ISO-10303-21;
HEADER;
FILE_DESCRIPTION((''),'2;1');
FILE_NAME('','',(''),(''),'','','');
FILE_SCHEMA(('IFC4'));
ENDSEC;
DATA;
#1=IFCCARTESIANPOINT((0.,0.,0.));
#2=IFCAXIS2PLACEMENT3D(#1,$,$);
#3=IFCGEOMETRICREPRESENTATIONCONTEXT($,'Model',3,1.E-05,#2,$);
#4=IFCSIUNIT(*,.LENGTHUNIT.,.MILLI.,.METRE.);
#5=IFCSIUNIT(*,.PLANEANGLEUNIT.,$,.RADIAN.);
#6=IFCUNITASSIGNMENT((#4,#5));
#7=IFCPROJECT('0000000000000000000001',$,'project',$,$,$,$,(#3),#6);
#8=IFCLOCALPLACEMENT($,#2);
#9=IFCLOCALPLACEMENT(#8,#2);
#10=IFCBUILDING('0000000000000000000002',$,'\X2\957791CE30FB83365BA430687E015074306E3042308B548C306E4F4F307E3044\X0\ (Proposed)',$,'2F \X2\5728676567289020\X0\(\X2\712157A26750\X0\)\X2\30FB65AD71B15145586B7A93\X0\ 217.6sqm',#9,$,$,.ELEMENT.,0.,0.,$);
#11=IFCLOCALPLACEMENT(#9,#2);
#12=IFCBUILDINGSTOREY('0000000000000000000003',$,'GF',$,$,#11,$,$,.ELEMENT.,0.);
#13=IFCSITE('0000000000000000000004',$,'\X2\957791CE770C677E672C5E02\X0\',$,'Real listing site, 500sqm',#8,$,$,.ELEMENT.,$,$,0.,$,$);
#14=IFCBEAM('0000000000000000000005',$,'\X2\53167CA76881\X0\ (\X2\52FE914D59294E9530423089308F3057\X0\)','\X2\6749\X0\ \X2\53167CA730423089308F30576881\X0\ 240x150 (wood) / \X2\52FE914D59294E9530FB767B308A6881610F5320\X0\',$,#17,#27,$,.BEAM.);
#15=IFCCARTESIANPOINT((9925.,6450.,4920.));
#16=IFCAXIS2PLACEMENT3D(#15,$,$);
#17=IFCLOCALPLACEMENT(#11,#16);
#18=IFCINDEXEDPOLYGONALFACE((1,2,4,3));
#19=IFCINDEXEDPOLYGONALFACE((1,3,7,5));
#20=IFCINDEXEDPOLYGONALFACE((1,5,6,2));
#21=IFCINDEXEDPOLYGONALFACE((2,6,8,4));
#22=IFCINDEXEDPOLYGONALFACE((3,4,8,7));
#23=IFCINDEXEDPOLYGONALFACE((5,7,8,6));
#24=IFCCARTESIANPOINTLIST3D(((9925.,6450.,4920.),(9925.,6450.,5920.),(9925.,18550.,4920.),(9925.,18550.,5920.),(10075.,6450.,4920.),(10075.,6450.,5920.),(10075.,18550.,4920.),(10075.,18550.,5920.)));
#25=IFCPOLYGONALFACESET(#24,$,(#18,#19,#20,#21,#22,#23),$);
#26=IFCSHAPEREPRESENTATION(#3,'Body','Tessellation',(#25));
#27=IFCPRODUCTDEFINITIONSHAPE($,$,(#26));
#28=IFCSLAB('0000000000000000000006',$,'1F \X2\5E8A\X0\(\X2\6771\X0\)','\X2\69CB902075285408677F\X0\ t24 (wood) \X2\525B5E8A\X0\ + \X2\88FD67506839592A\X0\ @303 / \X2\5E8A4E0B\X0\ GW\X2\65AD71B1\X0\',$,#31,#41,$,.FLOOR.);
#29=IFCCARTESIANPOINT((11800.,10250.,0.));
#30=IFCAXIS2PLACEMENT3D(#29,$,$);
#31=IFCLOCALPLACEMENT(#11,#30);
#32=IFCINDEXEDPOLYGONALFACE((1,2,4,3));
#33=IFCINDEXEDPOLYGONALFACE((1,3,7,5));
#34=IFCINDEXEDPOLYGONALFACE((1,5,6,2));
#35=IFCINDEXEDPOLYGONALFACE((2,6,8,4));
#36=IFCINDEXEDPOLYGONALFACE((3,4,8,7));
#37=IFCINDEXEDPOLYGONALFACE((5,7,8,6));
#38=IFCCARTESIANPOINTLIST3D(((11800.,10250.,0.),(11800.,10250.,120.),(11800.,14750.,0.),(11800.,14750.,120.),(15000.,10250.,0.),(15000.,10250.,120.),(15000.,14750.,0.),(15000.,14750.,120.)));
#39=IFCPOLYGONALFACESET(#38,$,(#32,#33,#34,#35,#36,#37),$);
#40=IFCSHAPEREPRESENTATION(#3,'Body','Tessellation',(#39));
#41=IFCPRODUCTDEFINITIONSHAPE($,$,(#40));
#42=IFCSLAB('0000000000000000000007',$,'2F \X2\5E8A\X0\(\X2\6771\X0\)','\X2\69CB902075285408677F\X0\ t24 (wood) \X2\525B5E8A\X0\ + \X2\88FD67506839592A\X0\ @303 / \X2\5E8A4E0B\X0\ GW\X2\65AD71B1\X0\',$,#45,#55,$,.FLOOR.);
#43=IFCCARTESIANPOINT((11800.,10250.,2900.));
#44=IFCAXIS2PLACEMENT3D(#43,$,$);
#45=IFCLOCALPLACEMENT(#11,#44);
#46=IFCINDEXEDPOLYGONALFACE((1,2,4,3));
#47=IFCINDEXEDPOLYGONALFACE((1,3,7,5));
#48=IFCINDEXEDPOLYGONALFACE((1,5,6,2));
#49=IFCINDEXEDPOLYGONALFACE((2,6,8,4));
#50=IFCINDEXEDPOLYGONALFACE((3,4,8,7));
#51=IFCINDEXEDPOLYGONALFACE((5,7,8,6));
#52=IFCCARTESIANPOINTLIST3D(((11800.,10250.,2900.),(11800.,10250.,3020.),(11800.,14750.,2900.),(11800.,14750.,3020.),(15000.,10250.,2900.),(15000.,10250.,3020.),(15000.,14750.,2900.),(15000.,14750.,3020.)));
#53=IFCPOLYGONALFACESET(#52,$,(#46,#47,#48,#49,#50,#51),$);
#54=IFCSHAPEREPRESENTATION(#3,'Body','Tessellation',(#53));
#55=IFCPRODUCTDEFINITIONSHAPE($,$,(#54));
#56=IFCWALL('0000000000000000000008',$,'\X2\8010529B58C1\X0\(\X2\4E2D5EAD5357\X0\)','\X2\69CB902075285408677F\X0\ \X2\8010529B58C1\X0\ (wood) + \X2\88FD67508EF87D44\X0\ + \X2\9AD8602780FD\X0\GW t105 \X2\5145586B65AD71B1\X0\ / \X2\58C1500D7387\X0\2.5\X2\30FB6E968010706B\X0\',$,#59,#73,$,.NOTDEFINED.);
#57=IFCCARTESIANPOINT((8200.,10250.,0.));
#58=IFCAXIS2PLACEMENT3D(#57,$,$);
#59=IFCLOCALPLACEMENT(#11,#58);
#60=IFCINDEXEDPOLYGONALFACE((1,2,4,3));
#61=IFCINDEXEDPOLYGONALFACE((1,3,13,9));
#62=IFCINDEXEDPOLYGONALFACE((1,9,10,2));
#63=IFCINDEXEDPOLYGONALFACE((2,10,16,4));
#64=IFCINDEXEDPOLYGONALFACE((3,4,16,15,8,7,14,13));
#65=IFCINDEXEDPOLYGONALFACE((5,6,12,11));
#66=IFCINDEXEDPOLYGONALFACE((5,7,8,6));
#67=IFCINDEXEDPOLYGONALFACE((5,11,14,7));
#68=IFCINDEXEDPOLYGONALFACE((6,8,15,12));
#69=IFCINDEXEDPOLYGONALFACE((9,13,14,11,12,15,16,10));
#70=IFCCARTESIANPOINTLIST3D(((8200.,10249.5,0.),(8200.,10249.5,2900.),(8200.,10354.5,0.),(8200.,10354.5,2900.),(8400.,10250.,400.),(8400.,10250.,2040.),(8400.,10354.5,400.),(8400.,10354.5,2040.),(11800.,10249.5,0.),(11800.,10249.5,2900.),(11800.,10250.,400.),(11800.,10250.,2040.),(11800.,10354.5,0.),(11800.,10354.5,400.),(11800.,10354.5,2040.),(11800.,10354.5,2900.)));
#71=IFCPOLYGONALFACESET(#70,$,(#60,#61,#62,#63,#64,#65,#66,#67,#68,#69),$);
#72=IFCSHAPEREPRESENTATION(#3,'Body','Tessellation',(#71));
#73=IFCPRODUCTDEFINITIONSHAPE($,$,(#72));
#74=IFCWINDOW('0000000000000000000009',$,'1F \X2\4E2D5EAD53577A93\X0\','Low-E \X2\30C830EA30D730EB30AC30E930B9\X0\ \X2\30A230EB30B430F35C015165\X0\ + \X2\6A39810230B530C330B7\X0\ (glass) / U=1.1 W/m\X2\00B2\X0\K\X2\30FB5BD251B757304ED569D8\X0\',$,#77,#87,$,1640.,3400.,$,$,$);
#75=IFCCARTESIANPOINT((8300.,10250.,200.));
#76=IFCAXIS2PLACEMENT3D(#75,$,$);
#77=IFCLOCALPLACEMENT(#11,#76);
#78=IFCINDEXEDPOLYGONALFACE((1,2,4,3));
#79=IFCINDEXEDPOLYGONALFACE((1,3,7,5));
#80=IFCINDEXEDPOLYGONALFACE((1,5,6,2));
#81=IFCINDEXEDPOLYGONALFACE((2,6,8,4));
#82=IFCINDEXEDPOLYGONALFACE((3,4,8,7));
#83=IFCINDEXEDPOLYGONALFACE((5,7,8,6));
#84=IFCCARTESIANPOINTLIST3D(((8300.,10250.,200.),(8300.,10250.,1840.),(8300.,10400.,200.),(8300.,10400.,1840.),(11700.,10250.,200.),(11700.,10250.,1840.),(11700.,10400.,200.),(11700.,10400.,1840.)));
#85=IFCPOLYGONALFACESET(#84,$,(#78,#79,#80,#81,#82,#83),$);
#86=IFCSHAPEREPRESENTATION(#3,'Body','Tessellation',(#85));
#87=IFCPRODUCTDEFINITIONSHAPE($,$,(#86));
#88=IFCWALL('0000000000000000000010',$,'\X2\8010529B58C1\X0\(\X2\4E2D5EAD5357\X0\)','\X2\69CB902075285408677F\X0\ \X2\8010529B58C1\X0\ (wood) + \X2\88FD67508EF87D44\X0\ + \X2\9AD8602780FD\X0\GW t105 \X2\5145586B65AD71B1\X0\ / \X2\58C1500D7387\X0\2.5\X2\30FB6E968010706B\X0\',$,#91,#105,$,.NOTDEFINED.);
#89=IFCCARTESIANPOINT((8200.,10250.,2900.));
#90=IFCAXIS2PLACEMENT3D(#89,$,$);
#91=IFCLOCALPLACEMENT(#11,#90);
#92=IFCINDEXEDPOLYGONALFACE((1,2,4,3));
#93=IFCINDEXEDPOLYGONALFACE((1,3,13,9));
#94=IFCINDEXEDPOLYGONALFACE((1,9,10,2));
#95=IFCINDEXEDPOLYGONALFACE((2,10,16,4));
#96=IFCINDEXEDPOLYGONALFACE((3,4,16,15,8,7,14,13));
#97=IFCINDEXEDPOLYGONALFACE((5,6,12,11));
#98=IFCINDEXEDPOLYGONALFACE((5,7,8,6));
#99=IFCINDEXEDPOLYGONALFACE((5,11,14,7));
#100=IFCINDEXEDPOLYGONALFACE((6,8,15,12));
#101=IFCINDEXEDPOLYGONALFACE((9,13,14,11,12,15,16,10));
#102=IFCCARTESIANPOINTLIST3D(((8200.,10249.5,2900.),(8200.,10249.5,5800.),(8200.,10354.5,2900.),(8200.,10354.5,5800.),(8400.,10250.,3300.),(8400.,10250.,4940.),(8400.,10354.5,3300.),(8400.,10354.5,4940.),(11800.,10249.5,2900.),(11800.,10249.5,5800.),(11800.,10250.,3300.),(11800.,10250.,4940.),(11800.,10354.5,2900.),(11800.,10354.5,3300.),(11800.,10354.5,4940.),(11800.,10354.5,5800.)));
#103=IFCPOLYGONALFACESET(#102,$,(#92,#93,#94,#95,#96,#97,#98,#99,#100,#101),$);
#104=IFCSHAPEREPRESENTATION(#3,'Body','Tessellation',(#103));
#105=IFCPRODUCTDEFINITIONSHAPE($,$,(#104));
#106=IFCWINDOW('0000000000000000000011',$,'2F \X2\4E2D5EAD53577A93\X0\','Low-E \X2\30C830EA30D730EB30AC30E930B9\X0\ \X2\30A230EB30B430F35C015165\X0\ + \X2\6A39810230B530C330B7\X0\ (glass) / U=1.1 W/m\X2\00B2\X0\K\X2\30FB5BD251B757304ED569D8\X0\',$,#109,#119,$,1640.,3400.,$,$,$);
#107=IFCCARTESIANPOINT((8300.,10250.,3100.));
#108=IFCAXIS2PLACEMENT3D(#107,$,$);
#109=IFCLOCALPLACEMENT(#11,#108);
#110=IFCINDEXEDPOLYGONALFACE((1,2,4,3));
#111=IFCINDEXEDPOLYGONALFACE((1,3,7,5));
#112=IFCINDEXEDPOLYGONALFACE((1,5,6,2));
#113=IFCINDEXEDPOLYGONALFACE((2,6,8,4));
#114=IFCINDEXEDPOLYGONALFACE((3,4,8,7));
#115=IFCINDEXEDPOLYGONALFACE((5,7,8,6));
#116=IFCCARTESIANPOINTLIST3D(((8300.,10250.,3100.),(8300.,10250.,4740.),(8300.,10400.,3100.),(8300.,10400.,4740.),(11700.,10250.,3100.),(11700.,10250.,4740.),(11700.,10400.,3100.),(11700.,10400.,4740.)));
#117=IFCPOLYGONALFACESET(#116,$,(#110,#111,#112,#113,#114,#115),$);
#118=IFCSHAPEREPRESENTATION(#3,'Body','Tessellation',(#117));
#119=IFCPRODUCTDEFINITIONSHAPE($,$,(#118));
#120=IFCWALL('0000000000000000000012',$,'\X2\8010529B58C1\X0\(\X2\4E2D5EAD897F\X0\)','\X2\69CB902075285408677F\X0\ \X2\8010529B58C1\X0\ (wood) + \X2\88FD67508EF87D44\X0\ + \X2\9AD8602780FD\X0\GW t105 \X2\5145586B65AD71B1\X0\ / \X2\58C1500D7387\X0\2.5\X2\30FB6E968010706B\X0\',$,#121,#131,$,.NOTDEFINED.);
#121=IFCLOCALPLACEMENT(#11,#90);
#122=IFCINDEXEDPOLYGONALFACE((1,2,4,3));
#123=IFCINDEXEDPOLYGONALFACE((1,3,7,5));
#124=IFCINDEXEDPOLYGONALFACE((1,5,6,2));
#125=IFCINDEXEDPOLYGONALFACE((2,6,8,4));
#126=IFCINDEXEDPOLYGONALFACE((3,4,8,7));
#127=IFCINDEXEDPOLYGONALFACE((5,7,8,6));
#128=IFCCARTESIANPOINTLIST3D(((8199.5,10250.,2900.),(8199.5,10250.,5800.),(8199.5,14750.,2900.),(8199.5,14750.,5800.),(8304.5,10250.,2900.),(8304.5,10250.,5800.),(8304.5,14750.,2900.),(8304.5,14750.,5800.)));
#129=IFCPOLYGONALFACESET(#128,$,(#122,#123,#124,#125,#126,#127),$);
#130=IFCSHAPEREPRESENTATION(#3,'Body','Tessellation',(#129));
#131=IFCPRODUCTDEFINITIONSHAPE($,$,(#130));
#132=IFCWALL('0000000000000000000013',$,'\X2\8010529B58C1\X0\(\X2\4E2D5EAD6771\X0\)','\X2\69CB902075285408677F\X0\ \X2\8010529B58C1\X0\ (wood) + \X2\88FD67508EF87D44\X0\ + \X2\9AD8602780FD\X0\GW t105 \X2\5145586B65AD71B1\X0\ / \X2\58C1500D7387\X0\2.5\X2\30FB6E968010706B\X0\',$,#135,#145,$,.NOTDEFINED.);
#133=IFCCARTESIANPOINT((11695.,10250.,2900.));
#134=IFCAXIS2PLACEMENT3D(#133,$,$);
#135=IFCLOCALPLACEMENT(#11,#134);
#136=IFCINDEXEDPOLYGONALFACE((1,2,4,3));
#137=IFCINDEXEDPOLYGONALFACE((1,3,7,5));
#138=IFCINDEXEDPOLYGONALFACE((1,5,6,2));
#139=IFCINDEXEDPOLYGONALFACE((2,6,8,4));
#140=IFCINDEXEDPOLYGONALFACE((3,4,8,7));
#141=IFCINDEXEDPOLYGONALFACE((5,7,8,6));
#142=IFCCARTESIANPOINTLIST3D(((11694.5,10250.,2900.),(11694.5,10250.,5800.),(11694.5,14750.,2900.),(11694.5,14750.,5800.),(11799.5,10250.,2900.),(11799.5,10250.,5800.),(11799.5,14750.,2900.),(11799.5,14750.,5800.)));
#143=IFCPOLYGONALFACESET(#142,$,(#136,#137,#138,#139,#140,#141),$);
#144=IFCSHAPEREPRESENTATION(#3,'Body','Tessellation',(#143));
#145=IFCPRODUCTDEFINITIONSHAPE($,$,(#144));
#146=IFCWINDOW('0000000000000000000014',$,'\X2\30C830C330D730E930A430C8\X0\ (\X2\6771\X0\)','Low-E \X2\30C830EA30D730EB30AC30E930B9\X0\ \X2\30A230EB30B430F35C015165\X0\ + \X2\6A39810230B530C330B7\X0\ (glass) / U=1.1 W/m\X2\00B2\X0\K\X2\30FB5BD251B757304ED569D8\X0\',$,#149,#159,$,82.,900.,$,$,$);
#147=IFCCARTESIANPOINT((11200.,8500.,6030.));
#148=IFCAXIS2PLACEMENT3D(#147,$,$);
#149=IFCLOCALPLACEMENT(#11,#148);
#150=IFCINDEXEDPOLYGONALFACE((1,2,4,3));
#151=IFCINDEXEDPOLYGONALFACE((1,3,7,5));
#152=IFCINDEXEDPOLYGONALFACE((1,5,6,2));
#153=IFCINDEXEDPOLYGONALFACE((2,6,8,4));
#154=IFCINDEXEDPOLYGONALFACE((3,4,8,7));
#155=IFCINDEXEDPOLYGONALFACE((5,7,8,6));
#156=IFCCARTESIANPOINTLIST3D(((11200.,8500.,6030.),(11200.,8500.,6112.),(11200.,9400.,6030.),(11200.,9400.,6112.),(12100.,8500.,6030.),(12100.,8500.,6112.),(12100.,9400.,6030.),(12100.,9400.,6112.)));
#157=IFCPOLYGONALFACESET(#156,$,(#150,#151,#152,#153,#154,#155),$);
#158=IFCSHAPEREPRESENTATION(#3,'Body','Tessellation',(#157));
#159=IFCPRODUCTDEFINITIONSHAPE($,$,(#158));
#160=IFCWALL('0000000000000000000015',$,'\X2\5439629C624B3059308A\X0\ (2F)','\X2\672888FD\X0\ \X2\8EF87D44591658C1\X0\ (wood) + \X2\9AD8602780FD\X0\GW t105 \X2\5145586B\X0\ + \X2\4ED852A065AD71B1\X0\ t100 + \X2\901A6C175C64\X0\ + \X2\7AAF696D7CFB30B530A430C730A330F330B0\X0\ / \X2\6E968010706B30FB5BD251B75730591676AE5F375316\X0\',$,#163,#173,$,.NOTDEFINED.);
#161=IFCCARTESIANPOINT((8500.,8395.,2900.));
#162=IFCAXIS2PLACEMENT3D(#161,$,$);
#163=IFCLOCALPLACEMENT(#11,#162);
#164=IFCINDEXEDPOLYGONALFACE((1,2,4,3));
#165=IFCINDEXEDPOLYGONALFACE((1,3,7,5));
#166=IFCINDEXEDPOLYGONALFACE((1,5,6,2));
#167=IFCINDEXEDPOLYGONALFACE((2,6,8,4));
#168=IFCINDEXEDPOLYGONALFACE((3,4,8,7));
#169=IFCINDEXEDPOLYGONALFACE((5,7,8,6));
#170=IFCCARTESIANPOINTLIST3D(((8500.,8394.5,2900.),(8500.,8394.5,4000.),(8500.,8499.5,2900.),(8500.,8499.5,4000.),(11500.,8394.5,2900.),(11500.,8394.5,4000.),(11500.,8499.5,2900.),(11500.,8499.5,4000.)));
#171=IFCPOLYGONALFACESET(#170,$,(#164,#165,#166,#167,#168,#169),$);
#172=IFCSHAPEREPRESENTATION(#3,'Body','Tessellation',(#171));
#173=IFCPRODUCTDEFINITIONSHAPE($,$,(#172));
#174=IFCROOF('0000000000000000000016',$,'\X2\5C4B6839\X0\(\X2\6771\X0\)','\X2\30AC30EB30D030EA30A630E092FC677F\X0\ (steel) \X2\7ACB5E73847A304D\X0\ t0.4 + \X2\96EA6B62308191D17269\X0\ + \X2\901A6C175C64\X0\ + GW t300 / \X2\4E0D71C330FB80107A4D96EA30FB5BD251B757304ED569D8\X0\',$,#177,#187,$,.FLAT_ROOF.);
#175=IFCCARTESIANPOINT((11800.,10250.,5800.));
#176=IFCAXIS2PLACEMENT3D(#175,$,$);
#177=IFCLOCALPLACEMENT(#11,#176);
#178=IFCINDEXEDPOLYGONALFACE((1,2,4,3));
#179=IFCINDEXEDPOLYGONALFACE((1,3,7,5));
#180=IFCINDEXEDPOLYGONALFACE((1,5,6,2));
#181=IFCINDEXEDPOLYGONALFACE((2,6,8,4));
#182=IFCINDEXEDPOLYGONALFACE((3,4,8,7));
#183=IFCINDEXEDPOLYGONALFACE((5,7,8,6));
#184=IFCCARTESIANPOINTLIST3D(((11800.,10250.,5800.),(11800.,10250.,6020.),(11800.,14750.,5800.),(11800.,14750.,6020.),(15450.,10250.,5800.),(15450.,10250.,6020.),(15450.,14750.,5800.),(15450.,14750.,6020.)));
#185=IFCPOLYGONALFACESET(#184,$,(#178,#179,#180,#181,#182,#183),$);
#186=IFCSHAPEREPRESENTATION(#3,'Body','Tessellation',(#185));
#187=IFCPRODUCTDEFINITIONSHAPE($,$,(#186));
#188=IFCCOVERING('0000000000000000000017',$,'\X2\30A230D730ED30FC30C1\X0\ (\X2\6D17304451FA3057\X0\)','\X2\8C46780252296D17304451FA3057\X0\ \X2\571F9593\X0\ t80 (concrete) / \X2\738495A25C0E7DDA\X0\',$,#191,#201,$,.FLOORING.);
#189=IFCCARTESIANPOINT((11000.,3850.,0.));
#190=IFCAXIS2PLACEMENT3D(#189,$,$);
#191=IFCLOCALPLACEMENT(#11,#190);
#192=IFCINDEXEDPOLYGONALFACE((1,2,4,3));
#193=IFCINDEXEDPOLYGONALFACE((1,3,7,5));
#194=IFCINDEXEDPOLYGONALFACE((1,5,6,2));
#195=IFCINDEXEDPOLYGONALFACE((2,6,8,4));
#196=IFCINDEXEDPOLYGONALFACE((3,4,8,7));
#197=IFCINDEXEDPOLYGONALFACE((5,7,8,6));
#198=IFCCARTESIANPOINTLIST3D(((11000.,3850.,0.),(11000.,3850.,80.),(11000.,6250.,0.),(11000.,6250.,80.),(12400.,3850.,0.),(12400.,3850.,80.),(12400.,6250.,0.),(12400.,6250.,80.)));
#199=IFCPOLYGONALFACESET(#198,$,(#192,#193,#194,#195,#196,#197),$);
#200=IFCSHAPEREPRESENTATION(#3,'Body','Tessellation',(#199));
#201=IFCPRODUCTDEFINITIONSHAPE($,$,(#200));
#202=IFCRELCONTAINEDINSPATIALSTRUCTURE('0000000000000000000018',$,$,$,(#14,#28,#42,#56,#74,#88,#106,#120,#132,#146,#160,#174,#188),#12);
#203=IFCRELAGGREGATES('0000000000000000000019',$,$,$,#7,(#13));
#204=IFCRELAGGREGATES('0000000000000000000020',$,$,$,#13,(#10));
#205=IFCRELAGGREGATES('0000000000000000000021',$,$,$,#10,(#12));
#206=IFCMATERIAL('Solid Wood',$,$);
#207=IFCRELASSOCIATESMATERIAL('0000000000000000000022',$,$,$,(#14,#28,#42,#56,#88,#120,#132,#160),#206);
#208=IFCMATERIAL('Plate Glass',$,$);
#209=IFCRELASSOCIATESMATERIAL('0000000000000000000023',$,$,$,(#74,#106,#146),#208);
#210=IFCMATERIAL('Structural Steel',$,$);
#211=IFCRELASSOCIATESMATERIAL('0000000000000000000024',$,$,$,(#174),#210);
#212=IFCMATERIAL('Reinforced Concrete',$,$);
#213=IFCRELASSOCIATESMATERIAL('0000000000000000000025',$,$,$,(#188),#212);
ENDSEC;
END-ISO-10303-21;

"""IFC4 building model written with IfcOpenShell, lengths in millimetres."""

from ifc_helpers import new_model, si_unit, frame, frame_2d, origin, place, context, project, spatial, rectangle, extrude, material, element, fill, save


model = new_model("IFC4")

# Units and contexts
model_context = context("Model", 3, precision=1e-05, world=origin())
ifc_project = project(units=[si_unit("LENGTHUNIT", "METRE", prefix="MILLI"), si_unit("PLANEANGLEUNIT", "RADIAN")], contexts=[model_context])

# Site, building, storey
site_placement = place(None, origin())
site = spatial("IfcSite", under=ifc_project, at=site_placement, Name="長野県松本市", ObjectType="Real listing site, 500sqm", CompositionType="ELEMENT", RefElevation=0.0)
building_placement = place(site_placement, origin())
building = spatial("IfcBuilding", under=site, at=building_placement, Name="長野・茶室と縁側のある和の住まい (Proposed)", ObjectType="2F 在来木造(無垢材)・断熱充填窓 217.6sqm", CompositionType="ELEMENT", ElevationOfRefHeight=0.0, ElevationOfTerrain=0.0)
storey_placement = place(building_placement, origin())
storey = spatial("IfcBuildingStorey", under=building, at=storey_placement, Name="GF", CompositionType="ELEMENT", Elevation=0.0)

# Shared definitions
ifc_material_1 = material(Name="Solid Wood")

# Beam
beam_placement = place(storey_placement, frame((9925.0, 6450.0, 4920.0)))
element("IfcBeam", 1, at=beam_placement, inside=storey, material=ifc_material_1, Name="化粧梁 (勾配天井あらわし)", Description="杉 化粧あらわし梁 240x150 (wood) / 勾配天井・登り梁意匠", PredefinedType="BEAM", context=model_context, shape_type="SweptSolid", body=[
    extrude(rectangle(XDim=150.0, YDim=12100.0, at=frame_2d((75.0, 6050.0))), frame((9925.0, 6450.0, 4920.0)), (0.0, 0.0, 1.0), 1000.0),
])

# Slabs
slab_1_placement = place(storey_placement, frame((11800.0, 10250.0, 0.0)))
element("IfcSlab", 2, at=slab_1_placement, inside=storey, material=ifc_material_1, Name="1F 床(東)", Description="構造用合板 t24 (wood) 剛床 + 製材根太 @303 / 床下 GW断熱", PredefinedType="FLOOR", context=model_context, shape_type="SweptSolid", body=[
    extrude(rectangle(XDim=3200.0, YDim=4500.0, at=frame_2d((1600.0, 2250.0))), frame((11800.0, 10250.0, 0.0)), (0.0, 0.0, 1.0), 120.0),
])
slab_2_placement = place(storey_placement, frame((11800.0, 10250.0, 2900.0)))
element("IfcSlab", 3, at=slab_2_placement, inside=storey, material=ifc_material_1, Name="2F 床(東)", Description="構造用合板 t24 (wood) 剛床 + 製材根太 @303 / 床下 GW断熱", PredefinedType="FLOOR", context=model_context, shape_type="SweptSolid", body=[
    extrude(rectangle(XDim=3200.0, YDim=4500.0, at=frame_2d((1600.0, 2250.0))), frame((11800.0, 10250.0, 2900.0)), (0.0, 0.0, 1.0), 120.0),
])

# Wall, opening, window
wall_1_placement = place(storey_placement, frame((8200.0, 10250.0, 0.0)))
wall_1 = element("IfcWall", 4, at=wall_1_placement, inside=storey, material=ifc_material_1, Name="耐力壁(中庭南)", Description="構造用合板 耐力壁 (wood) + 製材軸組 + 高性能GW t105 充填断熱 / 壁倍率2.5・準耐火", PredefinedType="NOTDEFINED", context=model_context, shape_type="SweptSolid", body=[
    extrude(rectangle(XDim=3600.0, YDim=105.0, at=frame_2d((1800.0, 52.0))), frame((8200.0, 10250.0, 0.0)), (0.0, 0.0, 1.0), 2900.0),
])
opening_1_placement = place(storey_placement, frame((8300.0, 10250.0, 200.0)))
opening_1 = element("IfcOpeningElement", 5, at=opening_1_placement, cuts=wall_1, PredefinedType="NOTDEFINED", context=model_context, shape_type="SweptSolid", body=[
    extrude(rectangle(XDim=3400.0, YDim=150.0, at=frame_2d((1700.0, 75.0))), frame((8300.0, 10250.0, 200.0)), (0.0, 0.0, 1.0), 1640.0),
])
ifc_material_2 = material(Name="Plate Glass")
window_1_placement = place(storey_placement, frame((8300.0, 10250.0, 200.0)))
window_1 = element("IfcWindow", 6, at=window_1_placement, inside=storey, material=ifc_material_2, Name="1F 中庭南窓", Description="Low-E トリプルガラス アルゴン封入 + 樹脂サッシ (glass) / U=1.1 W/m²K・寒冷地仕様", OverallHeight=1640.0, OverallWidth=3400.0, context=model_context, shape_type="SweptSolid", body=[
    extrude(rectangle(XDim=3400.0, YDim=150.0, at=frame_2d((1700.0, 75.0))), frame((8300.0, 10250.0, 200.0)), (0.0, 0.0, 1.0), 1640.0),
])
fill(opening_1, window_1)

# Wall, opening, window
wall_2_placement = place(storey_placement, frame((8200.0, 10250.0, 2900.0)))
wall_2 = element("IfcWall", 7, at=wall_2_placement, inside=storey, material=ifc_material_1, Name="耐力壁(中庭南)", Description="構造用合板 耐力壁 (wood) + 製材軸組 + 高性能GW t105 充填断熱 / 壁倍率2.5・準耐火", PredefinedType="NOTDEFINED", context=model_context, shape_type="SweptSolid", body=[
    extrude(rectangle(XDim=3600.0, YDim=105.0, at=frame_2d((1800.0, 52.0))), frame((8200.0, 10250.0, 2900.0)), (0.0, 0.0, 1.0), 2900.0),
])
opening_2_placement = place(storey_placement, frame((8300.0, 10250.0, 3100.0)))
opening_2 = element("IfcOpeningElement", 8, at=opening_2_placement, cuts=wall_2, PredefinedType="NOTDEFINED", context=model_context, shape_type="SweptSolid", body=[
    extrude(rectangle(XDim=3400.0, YDim=150.0, at=frame_2d((1700.0, 75.0))), frame((8300.0, 10250.0, 3100.0)), (0.0, 0.0, 1.0), 1640.0),
])
window_2_placement = place(storey_placement, frame((8300.0, 10250.0, 3100.0)))
window_2 = element("IfcWindow", 9, at=window_2_placement, inside=storey, material=ifc_material_2, Name="2F 中庭南窓", Description="Low-E トリプルガラス アルゴン封入 + 樹脂サッシ (glass) / U=1.1 W/m²K・寒冷地仕様", OverallHeight=1640.0, OverallWidth=3400.0, context=model_context, shape_type="SweptSolid", body=[
    extrude(rectangle(XDim=3400.0, YDim=150.0, at=frame_2d((1700.0, 75.0))), frame((8300.0, 10250.0, 3100.0)), (0.0, 0.0, 1.0), 1640.0),
])
fill(opening_2, window_2)

# Walls
wall_3_placement = place(storey_placement, frame((8200.0, 10250.0, 2900.0)))
element("IfcWall", 10, at=wall_3_placement, inside=storey, material=ifc_material_1, Name="耐力壁(中庭西)", Description="構造用合板 耐力壁 (wood) + 製材軸組 + 高性能GW t105 充填断熱 / 壁倍率2.5・準耐火", PredefinedType="NOTDEFINED", context=model_context, shape_type="SweptSolid", body=[
    extrude(rectangle(XDim=105.0, YDim=4500.0, at=frame_2d((52.0, 2250.0))), frame((8200.0, 10250.0, 2900.0)), (0.0, 0.0, 1.0), 2900.0),
])
wall_4_placement = place(storey_placement, frame((11695.0, 10250.0, 2900.0)))
element("IfcWall", 11, at=wall_4_placement, inside=storey, material=ifc_material_1, Name="耐力壁(中庭東)", Description="構造用合板 耐力壁 (wood) + 製材軸組 + 高性能GW t105 充填断熱 / 壁倍率2.5・準耐火", PredefinedType="NOTDEFINED", context=model_context, shape_type="SweptSolid", body=[
    extrude(rectangle(XDim=105.0, YDim=4500.0, at=frame_2d((52.0, 2250.0))), frame((11695.0, 10250.0, 2900.0)), (0.0, 0.0, 1.0), 2900.0),
])

# Window
window_3_placement = place(storey_placement, frame((11200.0, 8500.0, 6030.0)))
element("IfcWindow", 12, at=window_3_placement, inside=storey, material=ifc_material_2, Name="トップライト (東)", Description="Low-E トリプルガラス アルゴン封入 + 樹脂サッシ (glass) / U=1.1 W/m²K・寒冷地仕様", OverallHeight=82.0, OverallWidth=900.0, context=model_context, shape_type="SweptSolid", body=[
    extrude(rectangle(XDim=900.0, YDim=900.0, at=frame_2d((450.0, 450.0))), frame((11200.0, 8500.0, 6030.0)), (0.0, 0.0, 1.0), 82.0),
])

# Wall
wall_5_placement = place(storey_placement, frame((8500.0, 8395.0, 2900.0)))
element("IfcWall", 13, at=wall_5_placement, inside=storey, material=ifc_material_1, Name="吹抜手すり (2F)", Description="木製 軸組外壁 (wood) + 高性能GW t105 充填 + 付加断熱 t100 + 通気層 + 窯業系サイディング / 準耐火・寒冷地外皮強化", PredefinedType="NOTDEFINED", context=model_context, shape_type="SweptSolid", body=[
    extrude(rectangle(XDim=3000.0, YDim=105.0, at=frame_2d((1500.0, 52.0))), frame((8500.0, 8395.0, 2900.0)), (0.0, 0.0, 1.0), 1100.0),
])

# Roof
ifc_material_3 = material(Name="Structural Steel")
for number, where, name in (
    (14, (11800.0, 10250.0, 5800.0), "屋根(東)"),
):
    element("IfcRoof", number, at=place(storey_placement, frame(where)), inside=storey, material=ifc_material_3, Name=name, Description="ガルバリウム鋼板 (steel) 立平葺き t0.4 + 雪止め金物 + 通気層 + GW t300 / 不燃・耐積雪・寒冷地仕様", PredefinedType="FLAT_ROOF", context=model_context, shape_type="SweptSolid", body=[
        extrude(rectangle(XDim=3650.0, YDim=4500.0, at=frame_2d((1825.0, 2250.0))), frame((11800.0, 10250.0, 5800.0)), (0.0, 0.0, 1.0), 220.0),
    ])

# Covering
ifc_material_4 = material(Name="Reinforced Concrete")
covering_placement = place(storey_placement, frame((11000.0, 3850.0, 0.0)))
element("IfcCovering", 15, at=covering_placement, inside=storey, material=ifc_material_4, Name="アプローチ (洗い出し)", Description="豆砂利洗い出し 土間 t80 (concrete) / 玄関導線", PredefinedType="FLOORING", context=model_context, shape_type="SweptSolid", body=[
    extrude(rectangle(XDim=1400.0, YDim=2400.0, at=frame_2d((700.0, 1200.0))), frame((11000.0, 3850.0, 0.0)), (0.0, 0.0, 1.0), 80.0),
])

save(model, "model.ifc")
